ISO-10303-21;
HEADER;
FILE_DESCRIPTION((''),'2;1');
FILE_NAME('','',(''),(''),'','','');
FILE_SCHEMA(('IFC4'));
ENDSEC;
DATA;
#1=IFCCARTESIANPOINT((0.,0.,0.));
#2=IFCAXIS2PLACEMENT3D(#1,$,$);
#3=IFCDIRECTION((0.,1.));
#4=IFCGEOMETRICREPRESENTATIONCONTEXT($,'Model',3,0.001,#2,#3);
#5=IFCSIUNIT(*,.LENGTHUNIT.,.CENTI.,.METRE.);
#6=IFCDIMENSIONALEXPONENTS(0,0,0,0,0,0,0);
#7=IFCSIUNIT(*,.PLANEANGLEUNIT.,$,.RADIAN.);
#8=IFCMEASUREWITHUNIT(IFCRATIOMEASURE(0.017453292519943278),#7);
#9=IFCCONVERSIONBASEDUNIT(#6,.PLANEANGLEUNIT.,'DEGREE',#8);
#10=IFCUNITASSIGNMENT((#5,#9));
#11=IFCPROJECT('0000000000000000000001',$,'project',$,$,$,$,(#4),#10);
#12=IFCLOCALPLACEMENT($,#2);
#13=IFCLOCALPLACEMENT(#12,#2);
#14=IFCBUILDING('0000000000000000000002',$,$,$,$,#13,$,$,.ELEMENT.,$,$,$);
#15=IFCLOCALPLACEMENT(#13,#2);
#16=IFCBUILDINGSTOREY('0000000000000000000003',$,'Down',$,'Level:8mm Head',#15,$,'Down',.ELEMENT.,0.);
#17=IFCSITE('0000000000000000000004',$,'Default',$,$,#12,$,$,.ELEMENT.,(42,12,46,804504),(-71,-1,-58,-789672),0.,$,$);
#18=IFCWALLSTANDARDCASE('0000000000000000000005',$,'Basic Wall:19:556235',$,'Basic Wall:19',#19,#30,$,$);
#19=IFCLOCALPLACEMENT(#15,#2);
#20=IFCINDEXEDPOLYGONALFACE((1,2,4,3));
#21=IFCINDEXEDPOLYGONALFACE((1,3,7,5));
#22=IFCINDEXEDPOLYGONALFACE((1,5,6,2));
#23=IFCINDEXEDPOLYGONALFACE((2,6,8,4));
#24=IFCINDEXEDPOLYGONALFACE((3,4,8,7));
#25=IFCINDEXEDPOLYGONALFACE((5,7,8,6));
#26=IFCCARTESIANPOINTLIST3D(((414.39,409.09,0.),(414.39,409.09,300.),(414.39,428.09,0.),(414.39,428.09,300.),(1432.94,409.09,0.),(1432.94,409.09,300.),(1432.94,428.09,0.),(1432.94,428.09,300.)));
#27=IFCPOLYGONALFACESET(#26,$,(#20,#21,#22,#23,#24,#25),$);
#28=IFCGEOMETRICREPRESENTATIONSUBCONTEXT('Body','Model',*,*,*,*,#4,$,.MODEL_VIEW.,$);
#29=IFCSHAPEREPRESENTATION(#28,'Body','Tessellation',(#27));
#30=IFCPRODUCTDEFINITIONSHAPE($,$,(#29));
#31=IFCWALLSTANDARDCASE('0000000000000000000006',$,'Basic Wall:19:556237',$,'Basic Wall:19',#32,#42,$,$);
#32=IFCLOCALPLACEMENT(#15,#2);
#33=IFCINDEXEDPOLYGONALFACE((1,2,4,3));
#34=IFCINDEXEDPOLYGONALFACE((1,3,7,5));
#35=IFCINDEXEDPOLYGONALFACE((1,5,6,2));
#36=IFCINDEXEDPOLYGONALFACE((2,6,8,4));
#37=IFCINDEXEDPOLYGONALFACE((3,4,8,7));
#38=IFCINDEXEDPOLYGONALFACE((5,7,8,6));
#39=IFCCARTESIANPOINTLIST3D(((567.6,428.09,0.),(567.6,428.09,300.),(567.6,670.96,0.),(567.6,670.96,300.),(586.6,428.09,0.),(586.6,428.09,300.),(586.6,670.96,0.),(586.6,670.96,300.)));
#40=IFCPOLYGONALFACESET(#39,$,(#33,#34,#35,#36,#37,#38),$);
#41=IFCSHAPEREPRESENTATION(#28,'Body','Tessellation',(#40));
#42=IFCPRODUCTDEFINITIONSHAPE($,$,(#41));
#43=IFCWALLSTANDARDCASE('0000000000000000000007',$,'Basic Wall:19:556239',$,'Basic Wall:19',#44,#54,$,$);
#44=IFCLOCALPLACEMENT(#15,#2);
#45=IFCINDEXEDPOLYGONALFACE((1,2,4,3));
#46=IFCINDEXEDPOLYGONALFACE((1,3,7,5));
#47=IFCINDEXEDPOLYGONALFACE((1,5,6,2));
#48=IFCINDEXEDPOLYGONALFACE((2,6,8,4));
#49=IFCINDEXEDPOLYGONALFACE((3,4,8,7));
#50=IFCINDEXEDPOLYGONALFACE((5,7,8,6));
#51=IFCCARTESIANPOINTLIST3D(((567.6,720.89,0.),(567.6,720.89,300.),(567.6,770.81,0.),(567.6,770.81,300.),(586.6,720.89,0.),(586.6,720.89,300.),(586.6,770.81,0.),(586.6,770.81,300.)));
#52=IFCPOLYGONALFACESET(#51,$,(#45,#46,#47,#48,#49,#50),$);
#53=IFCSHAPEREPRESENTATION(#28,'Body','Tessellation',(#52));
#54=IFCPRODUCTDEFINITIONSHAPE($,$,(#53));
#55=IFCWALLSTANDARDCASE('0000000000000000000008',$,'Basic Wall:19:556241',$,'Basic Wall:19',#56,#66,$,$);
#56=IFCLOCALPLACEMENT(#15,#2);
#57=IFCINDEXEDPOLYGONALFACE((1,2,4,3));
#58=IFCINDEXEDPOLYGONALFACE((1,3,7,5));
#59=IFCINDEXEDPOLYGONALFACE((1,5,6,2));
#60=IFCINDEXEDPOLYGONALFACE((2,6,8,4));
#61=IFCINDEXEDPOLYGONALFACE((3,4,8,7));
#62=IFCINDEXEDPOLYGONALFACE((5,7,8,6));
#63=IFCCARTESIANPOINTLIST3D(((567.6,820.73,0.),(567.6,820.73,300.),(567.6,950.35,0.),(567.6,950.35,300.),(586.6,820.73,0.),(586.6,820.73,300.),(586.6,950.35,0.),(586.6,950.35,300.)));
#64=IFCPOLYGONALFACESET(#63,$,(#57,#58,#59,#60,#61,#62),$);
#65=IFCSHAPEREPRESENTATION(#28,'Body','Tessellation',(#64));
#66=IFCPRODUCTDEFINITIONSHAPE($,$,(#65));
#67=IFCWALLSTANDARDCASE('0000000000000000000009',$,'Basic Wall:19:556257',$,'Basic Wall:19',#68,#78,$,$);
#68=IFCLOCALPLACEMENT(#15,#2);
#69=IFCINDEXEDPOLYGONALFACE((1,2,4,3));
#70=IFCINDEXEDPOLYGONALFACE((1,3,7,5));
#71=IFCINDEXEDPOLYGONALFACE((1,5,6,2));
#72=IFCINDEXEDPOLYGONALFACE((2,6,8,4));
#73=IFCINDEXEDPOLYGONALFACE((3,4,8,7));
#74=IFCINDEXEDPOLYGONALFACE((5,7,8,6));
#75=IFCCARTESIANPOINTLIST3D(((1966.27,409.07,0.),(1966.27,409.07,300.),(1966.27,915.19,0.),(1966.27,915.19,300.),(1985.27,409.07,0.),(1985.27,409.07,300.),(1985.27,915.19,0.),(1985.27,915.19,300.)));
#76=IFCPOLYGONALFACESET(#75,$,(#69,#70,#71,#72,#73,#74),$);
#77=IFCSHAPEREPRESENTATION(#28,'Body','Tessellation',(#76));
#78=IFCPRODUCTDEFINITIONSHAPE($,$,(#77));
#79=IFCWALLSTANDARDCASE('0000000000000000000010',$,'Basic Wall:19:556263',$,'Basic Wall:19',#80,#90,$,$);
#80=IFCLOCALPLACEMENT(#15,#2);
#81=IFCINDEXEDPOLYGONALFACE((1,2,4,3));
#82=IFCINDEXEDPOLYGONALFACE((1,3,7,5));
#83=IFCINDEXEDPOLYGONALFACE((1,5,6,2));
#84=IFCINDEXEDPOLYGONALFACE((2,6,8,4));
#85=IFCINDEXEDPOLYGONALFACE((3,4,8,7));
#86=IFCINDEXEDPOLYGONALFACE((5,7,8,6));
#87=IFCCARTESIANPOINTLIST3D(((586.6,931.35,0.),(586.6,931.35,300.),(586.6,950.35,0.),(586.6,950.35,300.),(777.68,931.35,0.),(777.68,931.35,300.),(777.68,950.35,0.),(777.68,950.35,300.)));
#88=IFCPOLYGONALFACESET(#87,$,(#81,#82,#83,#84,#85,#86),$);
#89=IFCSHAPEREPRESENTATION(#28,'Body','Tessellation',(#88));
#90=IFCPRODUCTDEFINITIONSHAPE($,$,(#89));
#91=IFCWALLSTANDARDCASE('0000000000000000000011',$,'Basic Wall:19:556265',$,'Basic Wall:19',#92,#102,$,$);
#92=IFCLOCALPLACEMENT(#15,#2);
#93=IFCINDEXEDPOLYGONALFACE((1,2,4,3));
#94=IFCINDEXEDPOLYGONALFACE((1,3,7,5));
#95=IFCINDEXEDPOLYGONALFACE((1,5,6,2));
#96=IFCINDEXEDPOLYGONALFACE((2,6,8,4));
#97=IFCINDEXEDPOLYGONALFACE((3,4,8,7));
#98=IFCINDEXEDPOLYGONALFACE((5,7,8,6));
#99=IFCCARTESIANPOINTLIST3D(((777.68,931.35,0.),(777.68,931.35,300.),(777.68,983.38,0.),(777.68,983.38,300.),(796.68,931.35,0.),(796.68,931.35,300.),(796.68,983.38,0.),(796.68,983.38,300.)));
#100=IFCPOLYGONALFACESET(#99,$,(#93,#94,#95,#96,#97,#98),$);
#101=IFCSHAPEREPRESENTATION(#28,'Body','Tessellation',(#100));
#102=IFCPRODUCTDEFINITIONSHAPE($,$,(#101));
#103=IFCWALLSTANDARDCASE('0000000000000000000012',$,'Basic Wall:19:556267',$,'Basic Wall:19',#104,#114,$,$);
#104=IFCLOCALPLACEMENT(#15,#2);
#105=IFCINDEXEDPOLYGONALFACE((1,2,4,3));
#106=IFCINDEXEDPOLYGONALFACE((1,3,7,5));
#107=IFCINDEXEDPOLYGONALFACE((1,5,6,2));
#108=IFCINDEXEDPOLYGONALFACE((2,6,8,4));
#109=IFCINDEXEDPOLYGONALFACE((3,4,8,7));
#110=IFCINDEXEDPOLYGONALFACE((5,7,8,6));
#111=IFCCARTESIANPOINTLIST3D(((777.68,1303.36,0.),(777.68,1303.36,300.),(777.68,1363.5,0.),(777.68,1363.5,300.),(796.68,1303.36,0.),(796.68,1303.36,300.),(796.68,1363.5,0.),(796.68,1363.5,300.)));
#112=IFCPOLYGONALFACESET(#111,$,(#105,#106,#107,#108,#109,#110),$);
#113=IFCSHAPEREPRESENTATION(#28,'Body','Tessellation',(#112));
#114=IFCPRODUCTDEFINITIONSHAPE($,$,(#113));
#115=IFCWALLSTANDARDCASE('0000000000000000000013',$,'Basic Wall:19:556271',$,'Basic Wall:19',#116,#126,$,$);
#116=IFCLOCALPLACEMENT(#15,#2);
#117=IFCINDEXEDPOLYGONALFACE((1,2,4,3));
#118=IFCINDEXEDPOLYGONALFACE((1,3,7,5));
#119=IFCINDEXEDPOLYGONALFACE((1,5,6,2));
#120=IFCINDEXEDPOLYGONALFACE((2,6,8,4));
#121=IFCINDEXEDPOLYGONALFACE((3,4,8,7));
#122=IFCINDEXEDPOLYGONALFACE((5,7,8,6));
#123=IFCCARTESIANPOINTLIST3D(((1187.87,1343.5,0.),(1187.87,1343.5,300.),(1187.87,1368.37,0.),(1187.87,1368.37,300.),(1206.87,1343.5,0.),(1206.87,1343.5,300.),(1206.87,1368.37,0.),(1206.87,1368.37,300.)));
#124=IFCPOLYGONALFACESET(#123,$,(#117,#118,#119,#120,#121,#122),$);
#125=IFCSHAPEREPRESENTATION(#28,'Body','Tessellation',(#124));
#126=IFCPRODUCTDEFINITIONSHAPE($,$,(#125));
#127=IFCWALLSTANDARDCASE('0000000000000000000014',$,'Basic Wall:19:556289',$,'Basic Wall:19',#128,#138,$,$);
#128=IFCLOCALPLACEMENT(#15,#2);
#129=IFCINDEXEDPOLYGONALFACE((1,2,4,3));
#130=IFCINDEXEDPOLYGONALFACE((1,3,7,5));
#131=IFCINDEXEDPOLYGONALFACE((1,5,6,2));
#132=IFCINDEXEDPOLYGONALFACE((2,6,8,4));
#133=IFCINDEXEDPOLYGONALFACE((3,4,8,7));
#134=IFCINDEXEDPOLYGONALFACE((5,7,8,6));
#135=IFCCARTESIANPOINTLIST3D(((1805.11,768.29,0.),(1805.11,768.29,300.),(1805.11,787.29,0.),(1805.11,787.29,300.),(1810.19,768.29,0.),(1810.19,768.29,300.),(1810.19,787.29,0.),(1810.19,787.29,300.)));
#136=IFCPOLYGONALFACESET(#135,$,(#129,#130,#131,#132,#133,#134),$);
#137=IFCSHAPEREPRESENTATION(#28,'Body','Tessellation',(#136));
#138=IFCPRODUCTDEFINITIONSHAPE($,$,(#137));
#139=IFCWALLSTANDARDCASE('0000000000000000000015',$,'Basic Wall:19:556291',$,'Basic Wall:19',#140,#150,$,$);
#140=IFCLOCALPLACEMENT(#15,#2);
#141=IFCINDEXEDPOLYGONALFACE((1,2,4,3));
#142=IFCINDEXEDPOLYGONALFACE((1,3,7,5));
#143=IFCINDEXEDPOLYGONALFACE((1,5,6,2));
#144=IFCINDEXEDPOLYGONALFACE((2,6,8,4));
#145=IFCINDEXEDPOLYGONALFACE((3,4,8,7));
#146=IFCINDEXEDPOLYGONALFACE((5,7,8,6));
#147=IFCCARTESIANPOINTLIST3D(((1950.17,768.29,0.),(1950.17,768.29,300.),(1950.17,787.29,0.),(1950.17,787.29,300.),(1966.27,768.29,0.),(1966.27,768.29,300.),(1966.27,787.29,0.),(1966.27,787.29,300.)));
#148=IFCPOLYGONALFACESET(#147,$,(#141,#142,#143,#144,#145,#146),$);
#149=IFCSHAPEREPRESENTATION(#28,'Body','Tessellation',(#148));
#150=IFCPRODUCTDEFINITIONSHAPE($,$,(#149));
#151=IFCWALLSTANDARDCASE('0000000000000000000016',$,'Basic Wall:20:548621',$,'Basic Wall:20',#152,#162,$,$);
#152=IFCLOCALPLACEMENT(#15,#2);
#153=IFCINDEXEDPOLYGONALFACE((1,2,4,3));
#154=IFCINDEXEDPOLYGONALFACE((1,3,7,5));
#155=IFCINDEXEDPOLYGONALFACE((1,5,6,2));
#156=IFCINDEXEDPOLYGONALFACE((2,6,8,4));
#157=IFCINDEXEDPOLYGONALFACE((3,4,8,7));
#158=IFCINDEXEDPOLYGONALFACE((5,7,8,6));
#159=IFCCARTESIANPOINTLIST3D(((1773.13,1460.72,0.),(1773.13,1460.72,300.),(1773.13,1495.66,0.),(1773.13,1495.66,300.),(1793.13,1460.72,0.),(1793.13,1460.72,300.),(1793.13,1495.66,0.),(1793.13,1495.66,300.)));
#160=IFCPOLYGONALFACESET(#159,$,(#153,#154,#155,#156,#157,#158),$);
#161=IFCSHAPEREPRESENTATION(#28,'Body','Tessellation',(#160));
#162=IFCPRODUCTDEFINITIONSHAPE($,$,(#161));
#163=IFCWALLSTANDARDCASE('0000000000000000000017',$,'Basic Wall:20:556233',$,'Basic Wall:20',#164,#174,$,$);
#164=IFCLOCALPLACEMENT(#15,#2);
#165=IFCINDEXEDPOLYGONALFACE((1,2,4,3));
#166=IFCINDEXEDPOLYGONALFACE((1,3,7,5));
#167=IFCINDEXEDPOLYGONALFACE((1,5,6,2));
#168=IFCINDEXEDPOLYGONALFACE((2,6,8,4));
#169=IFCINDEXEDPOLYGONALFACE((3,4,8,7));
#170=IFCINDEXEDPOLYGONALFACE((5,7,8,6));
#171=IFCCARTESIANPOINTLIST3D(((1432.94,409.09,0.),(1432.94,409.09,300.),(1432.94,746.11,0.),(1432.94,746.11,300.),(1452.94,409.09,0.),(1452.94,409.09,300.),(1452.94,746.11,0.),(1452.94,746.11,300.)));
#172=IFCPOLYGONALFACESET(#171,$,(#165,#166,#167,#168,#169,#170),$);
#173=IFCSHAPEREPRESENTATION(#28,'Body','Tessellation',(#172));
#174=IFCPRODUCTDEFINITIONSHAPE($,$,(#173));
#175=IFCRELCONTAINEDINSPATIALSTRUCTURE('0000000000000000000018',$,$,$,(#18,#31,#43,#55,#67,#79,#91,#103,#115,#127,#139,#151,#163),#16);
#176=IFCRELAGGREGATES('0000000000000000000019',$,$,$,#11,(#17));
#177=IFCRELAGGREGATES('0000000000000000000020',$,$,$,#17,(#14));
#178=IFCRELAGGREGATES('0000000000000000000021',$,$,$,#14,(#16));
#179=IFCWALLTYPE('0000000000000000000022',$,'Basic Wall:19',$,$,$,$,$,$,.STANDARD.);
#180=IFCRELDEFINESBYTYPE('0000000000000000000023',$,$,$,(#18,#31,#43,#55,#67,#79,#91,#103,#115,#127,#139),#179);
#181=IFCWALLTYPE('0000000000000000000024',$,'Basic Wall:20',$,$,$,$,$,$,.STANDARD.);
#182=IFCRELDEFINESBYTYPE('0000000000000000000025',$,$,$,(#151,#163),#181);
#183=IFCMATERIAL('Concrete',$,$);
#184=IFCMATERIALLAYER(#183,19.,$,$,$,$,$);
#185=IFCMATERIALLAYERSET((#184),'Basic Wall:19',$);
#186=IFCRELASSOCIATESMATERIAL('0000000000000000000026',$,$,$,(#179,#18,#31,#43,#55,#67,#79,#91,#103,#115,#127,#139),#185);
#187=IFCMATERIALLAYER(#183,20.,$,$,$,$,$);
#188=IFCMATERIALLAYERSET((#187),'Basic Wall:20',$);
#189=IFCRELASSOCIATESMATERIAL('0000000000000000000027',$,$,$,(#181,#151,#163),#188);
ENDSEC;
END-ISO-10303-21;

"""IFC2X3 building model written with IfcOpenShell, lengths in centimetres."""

from ifc_helpers import new_model, entity, si_unit, converted_unit, direction, frame, frame_2d, origin, place, context, subcontext, project, spatial, rectangle, extrude, material, layer, layer_set, layer_usage, type_object, element, save


model = new_model("IFC2X3")

# Units and contexts
model_context = context("Model", 3, precision=0.001, world=origin(), true_north=direction((0.0, 1.0)))
body_context = subcontext(model_context, "Body", "Model", "MODEL_VIEW")
ifc_project = project(units=[si_unit("LENGTHUNIT", "METRE", prefix="CENTI"), converted_unit("PLANEANGLEUNIT", "DEGREE", entity("IfcRatioMeasure", 0.017453292519943278), si_unit("PLANEANGLEUNIT", "RADIAN"), dimensions=[0, 0, 0, 0, 0, 0, 0])], contexts=[model_context])

# Site, building, storey
site_placement = place(None, origin())
site = spatial("IfcSite", under=ifc_project, at=site_placement, Name="Default", CompositionType="ELEMENT", RefLatitude=(42, 12, 46, 804504), RefLongitude=(-71, -1, -58, -789672), RefElevation=0.0)
building_placement = place(site_placement, origin())
building = spatial("IfcBuilding", under=site, at=building_placement, CompositionType="ELEMENT")
storey_placement = place(building_placement, origin())
storey = spatial("IfcBuildingStorey", under=building, at=storey_placement, Name="Down", ObjectType="Level:8mm Head", LongName="Down", CompositionType="ELEMENT", Elevation=0.0)

# Walls
ifc_material = material(Name="Concrete")
ifc_layer_1 = layer(ifc_material, 19.0)
ifc_layer_set_1 = layer_set([ifc_layer_1], Name="Basic Wall:19")
ifc_layer_usage_1 = layer_usage(ifc_layer_set_1, "AXIS2", "NEGATIVE", 9.5)
wall_type_1 = type_object("IfcWallType", Name="Basic Wall:19", PredefinedType="STANDARD", material=ifc_layer_set_1)
wall_1_placement = place(storey_placement, frame((1432.94, 418.59, 0.0), z_axis=(0.0, 0.0, 1.0), x_axis=(-1.0, 0.0, 0.0)))
element("IfcWallStandardCase", 1, at=wall_1_placement, inside=storey, type_object=wall_type_1, material=ifc_layer_usage_1, Name="Basic Wall:19:556235", ObjectType="Basic Wall:19", context=body_context, shape_type="SweptSolid", body=[
    extrude(rectangle(XDim=1018.55, YDim=19.0, at=frame_2d((509.27, 0.0), x_axis=(-1.0, 0.0))), origin(), (0.0, 0.0, 1.0), 300.0),
])
ifc_layer_usage_2 = layer_usage(ifc_layer_set_1, "AXIS2", "POSITIVE", -9.5)
wall_2_placement = place(storey_placement, frame((577.1, 428.09, 0.0), z_axis=(0.0, 0.0, 1.0), x_axis=(0.0, 1.0, 0.0)))
element("IfcWallStandardCase", 2, at=wall_2_placement, inside=storey, type_object=wall_type_1, material=ifc_layer_usage_2, Name="Basic Wall:19:556237", ObjectType="Basic Wall:19", context=body_context, shape_type="SweptSolid", body=[
    extrude(rectangle(XDim=242.88, YDim=19.0, at=frame_2d((121.44, 0.0), x_axis=(-1.0, 0.0))), origin(), (0.0, 0.0, 1.0), 300.0),
])
ifc_layer_usage_3 = layer_usage(ifc_layer_set_1, "AXIS2", "POSITIVE", -9.5)
wall_3_placement = place(storey_placement, frame((577.1, 720.89, 0.0), z_axis=(0.0, 0.0, 1.0), x_axis=(0.0, 1.0, 0.0)))
element("IfcWallStandardCase", 3, at=wall_3_placement, inside=storey, type_object=wall_type_1, material=ifc_layer_usage_3, Name="Basic Wall:19:556239", ObjectType="Basic Wall:19", context=body_context, shape_type="SweptSolid", body=[
    extrude(rectangle(XDim=49.92, YDim=19.0, at=frame_2d((24.96, 0.0), x_axis=(-1.0, 0.0))), origin(), (0.0, 0.0, 1.0), 300.0),
])
ifc_layer_usage_4 = layer_usage(ifc_layer_set_1, "AXIS2", "POSITIVE", -9.5)
wall_4_placement = place(storey_placement, frame((577.1, 820.73, 0.0), z_axis=(0.0, 0.0, 1.0), x_axis=(0.0, 1.0, 0.0)))
element("IfcWallStandardCase", 4, at=wall_4_placement, inside=storey, type_object=wall_type_1, material=ifc_layer_usage_4, Name="Basic Wall:19:556241", ObjectType="Basic Wall:19", context=body_context, shape_type="SweptSolid", body=[
    extrude(rectangle(XDim=129.61, YDim=19.0, at=frame_2d((64.81, 0.0), x_axis=(-1.0, 0.0))), origin(), (0.0, 0.0, 1.0), 300.0),
])
ifc_layer_usage_5 = layer_usage(ifc_layer_set_1, "AXIS2", "POSITIVE", -9.5)
wall_5_placement = place(storey_placement, frame((1975.77, 915.19, 0.0), z_axis=(0.0, 0.0, 1.0), x_axis=(0.0, -1.0, 0.0)))
element("IfcWallStandardCase", 5, at=wall_5_placement, inside=storey, type_object=wall_type_1, material=ifc_layer_usage_5, Name="Basic Wall:19:556257", ObjectType="Basic Wall:19", context=body_context, shape_type="SweptSolid", body=[
    extrude(rectangle(XDim=506.12, YDim=19.0, at=frame_2d((253.06, 0.0), x_axis=(-1.0, 0.0))), origin(), (0.0, 0.0, 1.0), 300.0),
])
ifc_layer_usage_6 = layer_usage(ifc_layer_set_1, "AXIS2", "NEGATIVE", 9.5)
wall_6_placement = place(storey_placement, frame((586.6, 940.85, 0.0)))
element("IfcWallStandardCase", 6, at=wall_6_placement, inside=storey, type_object=wall_type_1, material=ifc_layer_usage_6, Name="Basic Wall:19:556263", ObjectType="Basic Wall:19", context=body_context, shape_type="SweptSolid", body=[
    extrude(rectangle(XDim=191.07, YDim=19.0, at=frame_2d((95.54, 0.0), x_axis=(-1.0, 0.0))), origin(), (0.0, 0.0, 1.0), 300.0),
])
ifc_layer_usage_7 = layer_usage(ifc_layer_set_1, "AXIS2", "POSITIVE", -9.5)
wall_7_placement = place(storey_placement, frame((787.18, 931.35, 0.0), z_axis=(0.0, 0.0, 1.0), x_axis=(0.0, 1.0, 0.0)))
element("IfcWallStandardCase", 7, at=wall_7_placement, inside=storey, type_object=wall_type_1, material=ifc_layer_usage_7, Name="Basic Wall:19:556265", ObjectType="Basic Wall:19", context=body_context, shape_type="SweptSolid", body=[
    extrude(rectangle(XDim=52.04, YDim=19.0, at=frame_2d((26.02, 0.0), x_axis=(-1.0, 0.0))), origin(), (0.0, 0.0, 1.0), 300.0),
])
ifc_layer_usage_8 = layer_usage(ifc_layer_set_1, "AXIS2", "POSITIVE", -9.5)
wall_8_placement = place(storey_placement, frame((787.18, 1303.36, 0.0), z_axis=(0.0, 0.0, 1.0), x_axis=(0.0, 1.0, 0.0)))
element("IfcWallStandardCase", 8, at=wall_8_placement, inside=storey, type_object=wall_type_1, material=ifc_layer_usage_8, Name="Basic Wall:19:556267", ObjectType="Basic Wall:19", context=body_context, shape_type="SweptSolid", body=[
    extrude(rectangle(XDim=60.14, YDim=19.0, at=frame_2d((30.07, 0.0), x_axis=(-1.0, 0.0))), origin(), (0.0, 0.0, 1.0), 300.0),
])
ifc_layer_usage_9 = layer_usage(ifc_layer_set_1, "AXIS2", "POSITIVE", -9.5)
wall_9_placement = place(storey_placement, frame((1197.37, 1343.5, 0.0), z_axis=(0.0, 0.0, 1.0), x_axis=(0.0, 1.0, 0.0)))
element("IfcWallStandardCase", 9, at=wall_9_placement, inside=storey, type_object=wall_type_1, material=ifc_layer_usage_9, Name="Basic Wall:19:556271", ObjectType="Basic Wall:19", context=body_context, shape_type="SweptSolid", body=[
    extrude(rectangle(XDim=24.87, YDim=19.0, at=frame_2d((12.44, 0.0), x_axis=(-1.0, 0.0))), origin(), (0.0, 0.0, 1.0), 300.0),
])
ifc_layer_usage_10 = layer_usage(ifc_layer_set_1, "AXIS2", "NEGATIVE", 9.5)
wall_10_placement = place(storey_placement, frame((1805.11, 777.79, 0.0)))
element("IfcWallStandardCase", 10, at=wall_10_placement, inside=storey, type_object=wall_type_1, material=ifc_layer_usage_10, Name="Basic Wall:19:556289", ObjectType="Basic Wall:19", context=body_context, shape_type="SweptSolid", body=[
    extrude(rectangle(XDim=5.08, YDim=19.0, at=frame_2d((2.54, 0.0), x_axis=(-1.0, 0.0))), origin(), (0.0, 0.0, 1.0), 300.0),
])
ifc_layer_usage_11 = layer_usage(ifc_layer_set_1, "AXIS2", "NEGATIVE", 9.5)
wall_11_placement = place(storey_placement, frame((1950.17, 777.79, 0.0)))
element("IfcWallStandardCase", 11, at=wall_11_placement, inside=storey, type_object=wall_type_1, material=ifc_layer_usage_11, Name="Basic Wall:19:556291", ObjectType="Basic Wall:19", context=body_context, shape_type="SweptSolid", body=[
    extrude(rectangle(XDim=16.09, YDim=19.0, at=frame_2d((8.05, 0.0), x_axis=(-1.0, 0.0))), origin(), (0.0, 0.0, 1.0), 300.0),
])
ifc_layer_2 = layer(ifc_material, 20.0)
ifc_layer_set_2 = layer_set([ifc_layer_2], Name="Basic Wall:20")
ifc_layer_usage_12 = layer_usage(ifc_layer_set_2, "AXIS2", "NEGATIVE", 10.0)
wall_type_2 = type_object("IfcWallType", Name="Basic Wall:20", PredefinedType="STANDARD", material=ifc_layer_set_2)
wall_12_placement = place(storey_placement, frame((1783.13, 1460.72, 0.0), z_axis=(0.0, 0.0, 1.0), x_axis=(0.0, 1.0, 0.0)))
element("IfcWallStandardCase", 12, at=wall_12_placement, inside=storey, type_object=wall_type_2, material=ifc_layer_usage_12, Name="Basic Wall:20:548621", ObjectType="Basic Wall:20", context=body_context, shape_type="SweptSolid", body=[
    extrude(rectangle(XDim=34.94, YDim=20.0, at=frame_2d((17.47, 0.0), x_axis=(-1.0, 0.0))), origin(), (0.0, 0.0, 1.0), 300.0),
])
ifc_layer_usage_13 = layer_usage(ifc_layer_set_2, "AXIS2", "POSITIVE", -10.0)
wall_13_placement = place(storey_placement, frame((1442.94, 746.11, 0.0), z_axis=(0.0, 0.0, 1.0), x_axis=(0.0, -1.0, 0.0)))
element("IfcWallStandardCase", 13, at=wall_13_placement, inside=storey, type_object=wall_type_2, material=ifc_layer_usage_13, Name="Basic Wall:20:556233", ObjectType="Basic Wall:20", context=body_context, shape_type="SweptSolid", body=[
    extrude(rectangle(XDim=337.02, YDim=20.0, at=frame_2d((168.51, 0.0), x_axis=(-1.0, 0.0))), origin(), (0.0, 0.0, 1.0), 300.0),
])

save(model, "model.ifc")
